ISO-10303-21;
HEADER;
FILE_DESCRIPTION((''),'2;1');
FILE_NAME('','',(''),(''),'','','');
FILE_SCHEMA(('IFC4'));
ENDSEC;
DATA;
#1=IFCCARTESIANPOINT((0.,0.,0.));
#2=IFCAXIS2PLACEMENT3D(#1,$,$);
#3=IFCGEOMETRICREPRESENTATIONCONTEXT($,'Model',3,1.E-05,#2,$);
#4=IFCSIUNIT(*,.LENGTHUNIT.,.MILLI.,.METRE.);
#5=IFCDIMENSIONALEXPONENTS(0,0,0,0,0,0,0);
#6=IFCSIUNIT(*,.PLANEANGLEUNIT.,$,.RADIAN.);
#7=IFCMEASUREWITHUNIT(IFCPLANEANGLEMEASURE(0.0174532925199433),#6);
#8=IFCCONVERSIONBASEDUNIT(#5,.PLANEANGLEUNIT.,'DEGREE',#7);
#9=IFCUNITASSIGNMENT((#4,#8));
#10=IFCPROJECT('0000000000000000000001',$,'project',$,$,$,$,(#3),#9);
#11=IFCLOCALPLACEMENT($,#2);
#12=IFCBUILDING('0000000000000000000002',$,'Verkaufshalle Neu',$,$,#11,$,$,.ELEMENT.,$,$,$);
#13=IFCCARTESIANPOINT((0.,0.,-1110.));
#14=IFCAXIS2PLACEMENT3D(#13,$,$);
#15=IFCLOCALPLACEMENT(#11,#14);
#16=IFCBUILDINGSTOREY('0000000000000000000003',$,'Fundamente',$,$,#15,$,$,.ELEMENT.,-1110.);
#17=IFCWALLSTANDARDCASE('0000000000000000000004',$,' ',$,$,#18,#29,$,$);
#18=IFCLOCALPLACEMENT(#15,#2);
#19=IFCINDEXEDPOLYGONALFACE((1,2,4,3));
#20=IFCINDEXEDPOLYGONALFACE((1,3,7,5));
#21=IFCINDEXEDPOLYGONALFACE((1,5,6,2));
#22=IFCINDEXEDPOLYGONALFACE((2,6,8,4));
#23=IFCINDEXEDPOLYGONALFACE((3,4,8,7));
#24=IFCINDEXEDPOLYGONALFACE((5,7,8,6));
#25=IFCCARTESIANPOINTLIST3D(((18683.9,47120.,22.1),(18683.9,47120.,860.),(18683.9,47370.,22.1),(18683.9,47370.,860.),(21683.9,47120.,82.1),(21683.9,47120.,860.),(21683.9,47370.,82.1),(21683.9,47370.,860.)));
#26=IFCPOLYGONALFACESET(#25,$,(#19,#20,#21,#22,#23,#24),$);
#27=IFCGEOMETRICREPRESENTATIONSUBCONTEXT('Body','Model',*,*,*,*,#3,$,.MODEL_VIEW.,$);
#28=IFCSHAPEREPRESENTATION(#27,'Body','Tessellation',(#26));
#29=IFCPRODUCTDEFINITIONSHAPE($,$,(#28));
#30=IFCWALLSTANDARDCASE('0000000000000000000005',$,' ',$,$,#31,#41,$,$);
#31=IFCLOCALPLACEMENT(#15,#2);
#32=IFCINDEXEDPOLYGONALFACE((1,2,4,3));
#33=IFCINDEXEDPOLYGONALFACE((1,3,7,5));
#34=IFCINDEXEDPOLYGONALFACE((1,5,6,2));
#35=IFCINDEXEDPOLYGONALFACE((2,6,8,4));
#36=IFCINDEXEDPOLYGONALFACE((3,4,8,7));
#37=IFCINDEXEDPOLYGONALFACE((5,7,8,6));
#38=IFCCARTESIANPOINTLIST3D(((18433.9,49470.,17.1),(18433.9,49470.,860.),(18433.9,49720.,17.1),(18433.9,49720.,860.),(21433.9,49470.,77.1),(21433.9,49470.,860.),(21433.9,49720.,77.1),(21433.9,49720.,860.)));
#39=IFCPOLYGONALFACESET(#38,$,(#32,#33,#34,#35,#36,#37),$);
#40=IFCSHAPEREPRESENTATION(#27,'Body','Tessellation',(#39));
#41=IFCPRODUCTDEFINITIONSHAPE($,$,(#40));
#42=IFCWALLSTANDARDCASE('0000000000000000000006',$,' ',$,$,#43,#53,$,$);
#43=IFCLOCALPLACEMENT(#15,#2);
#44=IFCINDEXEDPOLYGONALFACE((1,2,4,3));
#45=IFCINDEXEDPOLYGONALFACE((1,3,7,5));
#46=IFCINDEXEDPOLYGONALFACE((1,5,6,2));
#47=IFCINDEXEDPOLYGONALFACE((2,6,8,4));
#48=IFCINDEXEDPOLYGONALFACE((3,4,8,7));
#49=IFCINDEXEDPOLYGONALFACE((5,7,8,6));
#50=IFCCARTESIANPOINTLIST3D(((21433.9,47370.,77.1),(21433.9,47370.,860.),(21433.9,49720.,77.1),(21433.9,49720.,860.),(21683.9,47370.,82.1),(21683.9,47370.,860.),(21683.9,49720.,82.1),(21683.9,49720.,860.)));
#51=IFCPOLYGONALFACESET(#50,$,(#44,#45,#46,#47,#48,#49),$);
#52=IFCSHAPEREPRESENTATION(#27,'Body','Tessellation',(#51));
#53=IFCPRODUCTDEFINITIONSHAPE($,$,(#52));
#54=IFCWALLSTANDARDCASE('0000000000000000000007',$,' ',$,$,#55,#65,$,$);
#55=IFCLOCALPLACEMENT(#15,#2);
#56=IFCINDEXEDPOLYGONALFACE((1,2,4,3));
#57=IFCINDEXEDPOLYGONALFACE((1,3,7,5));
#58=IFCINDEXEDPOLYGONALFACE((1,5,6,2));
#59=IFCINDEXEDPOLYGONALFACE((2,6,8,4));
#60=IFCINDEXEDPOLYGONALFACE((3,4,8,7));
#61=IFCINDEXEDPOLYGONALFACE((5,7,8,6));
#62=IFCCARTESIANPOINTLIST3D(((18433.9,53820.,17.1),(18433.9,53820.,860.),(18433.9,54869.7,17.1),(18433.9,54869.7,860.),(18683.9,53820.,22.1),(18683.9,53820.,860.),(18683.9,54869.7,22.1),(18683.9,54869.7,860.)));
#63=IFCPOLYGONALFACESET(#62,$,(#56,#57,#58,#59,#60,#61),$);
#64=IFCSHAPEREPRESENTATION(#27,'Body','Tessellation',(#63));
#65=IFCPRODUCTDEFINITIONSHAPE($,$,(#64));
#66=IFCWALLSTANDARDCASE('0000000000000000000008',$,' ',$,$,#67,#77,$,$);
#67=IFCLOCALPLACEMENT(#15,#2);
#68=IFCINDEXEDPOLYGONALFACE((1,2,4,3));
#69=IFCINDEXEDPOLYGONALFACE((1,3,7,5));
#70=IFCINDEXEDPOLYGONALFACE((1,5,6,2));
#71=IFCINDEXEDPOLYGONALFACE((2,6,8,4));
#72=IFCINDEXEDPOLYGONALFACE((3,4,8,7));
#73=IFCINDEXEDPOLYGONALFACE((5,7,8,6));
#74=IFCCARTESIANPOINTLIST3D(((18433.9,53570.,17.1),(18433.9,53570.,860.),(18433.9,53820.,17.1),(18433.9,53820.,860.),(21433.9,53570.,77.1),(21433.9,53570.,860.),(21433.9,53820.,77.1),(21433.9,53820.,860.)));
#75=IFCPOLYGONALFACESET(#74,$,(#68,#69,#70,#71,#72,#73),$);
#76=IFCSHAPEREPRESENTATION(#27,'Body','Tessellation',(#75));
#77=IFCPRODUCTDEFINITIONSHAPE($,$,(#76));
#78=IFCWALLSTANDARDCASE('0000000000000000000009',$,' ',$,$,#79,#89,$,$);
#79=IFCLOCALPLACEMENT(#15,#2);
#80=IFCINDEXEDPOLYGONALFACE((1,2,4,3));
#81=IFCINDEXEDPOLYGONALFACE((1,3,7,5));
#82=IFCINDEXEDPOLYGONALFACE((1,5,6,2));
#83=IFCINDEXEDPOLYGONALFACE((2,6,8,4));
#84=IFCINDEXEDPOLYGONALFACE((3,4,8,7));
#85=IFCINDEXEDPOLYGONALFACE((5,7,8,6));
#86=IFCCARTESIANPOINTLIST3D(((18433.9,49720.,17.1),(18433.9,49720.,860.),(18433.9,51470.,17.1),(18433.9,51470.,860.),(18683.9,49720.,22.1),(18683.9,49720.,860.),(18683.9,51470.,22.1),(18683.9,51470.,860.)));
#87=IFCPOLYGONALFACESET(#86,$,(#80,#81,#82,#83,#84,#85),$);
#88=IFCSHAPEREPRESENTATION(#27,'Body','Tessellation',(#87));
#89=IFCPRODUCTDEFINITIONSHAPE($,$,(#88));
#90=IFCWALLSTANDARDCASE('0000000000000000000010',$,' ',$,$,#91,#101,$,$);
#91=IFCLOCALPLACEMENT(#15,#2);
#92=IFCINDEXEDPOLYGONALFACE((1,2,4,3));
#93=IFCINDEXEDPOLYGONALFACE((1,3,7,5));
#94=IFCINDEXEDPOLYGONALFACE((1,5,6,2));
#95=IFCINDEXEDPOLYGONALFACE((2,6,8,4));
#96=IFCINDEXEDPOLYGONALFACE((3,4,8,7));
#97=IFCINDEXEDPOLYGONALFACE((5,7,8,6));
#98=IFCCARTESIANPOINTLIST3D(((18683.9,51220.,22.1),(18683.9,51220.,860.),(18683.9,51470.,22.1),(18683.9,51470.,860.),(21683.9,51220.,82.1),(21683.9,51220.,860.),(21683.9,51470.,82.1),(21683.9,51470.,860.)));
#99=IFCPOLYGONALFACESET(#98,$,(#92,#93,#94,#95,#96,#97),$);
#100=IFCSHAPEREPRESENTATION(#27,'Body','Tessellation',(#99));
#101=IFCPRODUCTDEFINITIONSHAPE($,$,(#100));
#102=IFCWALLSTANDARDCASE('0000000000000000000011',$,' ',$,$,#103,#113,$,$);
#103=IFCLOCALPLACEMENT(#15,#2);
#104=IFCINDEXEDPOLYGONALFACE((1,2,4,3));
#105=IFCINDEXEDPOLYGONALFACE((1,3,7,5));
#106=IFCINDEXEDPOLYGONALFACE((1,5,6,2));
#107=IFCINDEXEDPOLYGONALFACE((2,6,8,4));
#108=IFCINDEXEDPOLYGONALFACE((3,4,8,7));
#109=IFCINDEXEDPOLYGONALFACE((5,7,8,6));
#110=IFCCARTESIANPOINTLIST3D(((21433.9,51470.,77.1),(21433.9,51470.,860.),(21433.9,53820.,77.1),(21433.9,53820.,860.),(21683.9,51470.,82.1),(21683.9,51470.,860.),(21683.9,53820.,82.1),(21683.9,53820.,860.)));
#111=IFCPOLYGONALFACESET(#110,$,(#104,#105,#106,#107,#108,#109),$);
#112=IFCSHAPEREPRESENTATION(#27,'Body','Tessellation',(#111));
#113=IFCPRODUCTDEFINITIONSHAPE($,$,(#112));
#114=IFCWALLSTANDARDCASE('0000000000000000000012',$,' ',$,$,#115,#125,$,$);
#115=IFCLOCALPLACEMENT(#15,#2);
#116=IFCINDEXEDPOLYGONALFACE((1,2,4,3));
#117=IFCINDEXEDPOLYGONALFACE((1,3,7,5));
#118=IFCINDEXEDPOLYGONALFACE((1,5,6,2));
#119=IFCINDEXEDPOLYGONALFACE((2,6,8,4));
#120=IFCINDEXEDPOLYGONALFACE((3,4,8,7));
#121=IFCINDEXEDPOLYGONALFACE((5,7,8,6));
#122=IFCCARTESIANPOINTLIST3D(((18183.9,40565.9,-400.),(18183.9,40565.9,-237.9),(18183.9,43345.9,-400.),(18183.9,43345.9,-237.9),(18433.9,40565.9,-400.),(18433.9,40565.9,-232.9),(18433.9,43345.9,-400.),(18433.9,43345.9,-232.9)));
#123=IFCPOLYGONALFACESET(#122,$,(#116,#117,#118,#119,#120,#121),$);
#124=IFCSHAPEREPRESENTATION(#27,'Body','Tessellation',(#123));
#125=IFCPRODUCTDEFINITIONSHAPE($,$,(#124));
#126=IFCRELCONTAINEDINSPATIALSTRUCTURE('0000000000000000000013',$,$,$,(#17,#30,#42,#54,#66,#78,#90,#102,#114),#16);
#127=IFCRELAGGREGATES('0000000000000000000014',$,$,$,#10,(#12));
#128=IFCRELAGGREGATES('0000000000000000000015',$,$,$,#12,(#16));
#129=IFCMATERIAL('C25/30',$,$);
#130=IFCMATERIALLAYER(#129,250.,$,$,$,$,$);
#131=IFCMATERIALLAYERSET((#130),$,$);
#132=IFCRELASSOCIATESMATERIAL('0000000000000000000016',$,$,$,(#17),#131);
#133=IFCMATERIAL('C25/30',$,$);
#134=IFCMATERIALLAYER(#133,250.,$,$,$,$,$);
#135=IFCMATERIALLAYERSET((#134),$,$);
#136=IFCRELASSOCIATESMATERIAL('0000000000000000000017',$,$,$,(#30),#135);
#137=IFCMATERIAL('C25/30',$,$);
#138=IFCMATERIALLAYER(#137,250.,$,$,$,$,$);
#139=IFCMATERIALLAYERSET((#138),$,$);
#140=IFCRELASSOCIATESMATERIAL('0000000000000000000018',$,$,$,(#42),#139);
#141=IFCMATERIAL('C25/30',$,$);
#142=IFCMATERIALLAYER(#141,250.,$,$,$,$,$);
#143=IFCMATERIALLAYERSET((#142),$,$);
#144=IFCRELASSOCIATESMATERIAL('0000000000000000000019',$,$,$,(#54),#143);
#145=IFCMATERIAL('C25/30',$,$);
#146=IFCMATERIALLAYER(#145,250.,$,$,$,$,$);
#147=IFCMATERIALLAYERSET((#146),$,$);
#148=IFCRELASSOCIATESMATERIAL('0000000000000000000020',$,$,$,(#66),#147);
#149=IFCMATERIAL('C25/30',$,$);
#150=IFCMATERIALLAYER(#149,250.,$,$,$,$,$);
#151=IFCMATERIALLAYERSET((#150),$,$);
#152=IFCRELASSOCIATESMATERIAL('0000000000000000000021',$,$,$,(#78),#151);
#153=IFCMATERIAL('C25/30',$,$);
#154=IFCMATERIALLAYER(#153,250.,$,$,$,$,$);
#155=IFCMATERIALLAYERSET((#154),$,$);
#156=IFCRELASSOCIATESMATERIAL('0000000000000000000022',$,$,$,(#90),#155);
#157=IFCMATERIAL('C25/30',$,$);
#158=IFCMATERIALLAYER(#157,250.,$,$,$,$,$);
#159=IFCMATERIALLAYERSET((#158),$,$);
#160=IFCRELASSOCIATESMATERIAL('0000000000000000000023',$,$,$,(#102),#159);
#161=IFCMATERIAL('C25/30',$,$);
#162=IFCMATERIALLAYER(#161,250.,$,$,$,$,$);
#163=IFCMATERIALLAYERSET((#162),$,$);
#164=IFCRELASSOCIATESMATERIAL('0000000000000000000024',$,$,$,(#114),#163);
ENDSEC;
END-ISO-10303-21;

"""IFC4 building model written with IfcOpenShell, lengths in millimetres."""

from ifc_helpers import new_model, entity, si_unit, converted_unit, frame, frame_2d, origin, origin_with_axes, place, context, subcontext, project, spatial, rectangle, extrude, clip, halfspace, material, layer, layer_set, layer_usage, element, save


model = new_model("IFC4")

# Units and contexts
model_context = context("Model", 3, precision=1e-05, world=origin())
body_context = subcontext(model_context, "Body", "Model", "MODEL_VIEW")
ifc_project = project(units=[si_unit("LENGTHUNIT", "METRE", prefix="MILLI"), converted_unit("PLANEANGLEUNIT", "DEGREE", entity("IfcPlaneAngleMeasure", 0.0174532925199433), si_unit("PLANEANGLEUNIT", "RADIAN"), dimensions=[0, 0, 0, 0, 0, 0, 0])], contexts=[model_context])

# Building, storey
building_placement = place(None, origin())
building = spatial("IfcBuilding", under=ifc_project, at=building_placement, Name="Verkaufshalle Neu", CompositionType="ELEMENT")
storey_placement = place(building_placement, frame((0.0, 0.0, -1110.0)))
storey = spatial("IfcBuildingStorey", under=building, at=storey_placement, Name="Fundamente", CompositionType="ELEMENT", Elevation=-1110.0)

# Walls
ifc_material_1 = material(Name="C25/30")
ifc_layer_1 = layer(ifc_material_1, 250.0)
ifc_layer_set_1 = layer_set([ifc_layer_1])
ifc_layer_usage_1 = layer_usage(ifc_layer_set_1, "AXIS2", "POSITIVE", 0.0)
wall_1_placement = place(storey_placement, frame((18683.9, 47120.0, 22.1)))
element("IfcWallStandardCase", 1, at=wall_1_placement, inside=storey, material=ifc_layer_usage_1, Name=" ", context=body_context, shape_type="Clipping", body=[
    clip(extrude(rectangle(XDim=3000.0, YDim=250.0, at=frame_2d((1500.0, 125.0), x_axis=(1.0, 0.0))), origin_with_axes(), (0.0, 0.0, 1.0), 837.9), halfspace(frame((1500.0, 125.0, 30.0), z_axis=(-0.019996, 0.0, 0.9998), x_axis=(0.0, -1.0, 0.0)), True)),
])
ifc_material_2 = material(Name="C25/30")
ifc_layer_2 = layer(ifc_material_2, 250.0)
ifc_layer_set_2 = layer_set([ifc_layer_2])
ifc_layer_usage_2 = layer_usage(ifc_layer_set_2, "AXIS2", "POSITIVE", 0.0)
wall_2_placement = place(storey_placement, frame((21433.9, 49720.0, 17.1), z_axis=(0.0, 0.0, 1.0), x_axis=(-1.0, 0.0, 0.0)))
element("IfcWallStandardCase", 2, at=wall_2_placement, inside=storey, material=ifc_layer_usage_2, Name=" ", context=body_context, shape_type="Clipping", body=[
    clip(extrude(rectangle(XDim=3000.0, YDim=250.0, at=frame_2d((1500.0, 125.0), x_axis=(1.0, 0.0))), origin_with_axes(), (0.0, 0.0, 1.0), 842.9), halfspace(frame((1500.0, 125.0, 30.0), z_axis=(0.019996, 0.0, 0.9998), x_axis=(0.0, -1.0, 0.0)), True)),
])
ifc_material_3 = material(Name="C25/30")
ifc_layer_3 = layer(ifc_material_3, 250.0)
ifc_layer_set_3 = layer_set([ifc_layer_3])
ifc_layer_usage_3 = layer_usage(ifc_layer_set_3, "AXIS2", "POSITIVE", 0.0)
wall_3_placement = place(storey_placement, frame((21683.9, 47370.0, 77.1), z_axis=(0.0, 0.0, 1.0), x_axis=(0.0, 1.0, 0.0)))
element("IfcWallStandardCase", 3, at=wall_3_placement, inside=storey, material=ifc_layer_usage_3, Name=" ", context=body_context, shape_type="Clipping", body=[
    clip(extrude(rectangle(XDim=2350.0, YDim=250.0, at=frame_2d((1175.0, 125.0), x_axis=(1.0, 0.0))), origin_with_axes(), (0.0, 0.0, 1.0), 782.9), halfspace(frame((1175.0, 125.0, 2.5), z_axis=(0.0, 0.019996, 0.9998), x_axis=(0.0, -0.9998, 0.019996)), True)),
])
ifc_material_4 = material(Name="C25/30")
ifc_layer_4 = layer(ifc_material_4, 250.0)
ifc_layer_set_4 = layer_set([ifc_layer_4])
ifc_layer_usage_4 = layer_usage(ifc_layer_set_4, "AXIS2", "POSITIVE", 0.0)
wall_4_placement = place(storey_placement, frame((18683.9, 53820.0, 17.1), z_axis=(0.0, 0.0, 1.0), x_axis=(0.0, 1.0, 0.0)))
element("IfcWallStandardCase", 4, at=wall_4_placement, inside=storey, material=ifc_layer_usage_4, Name=" ", context=body_context, shape_type="Clipping", body=[
    clip(extrude(rectangle(XDim=1049.7, YDim=250.0, at=frame_2d((524.9, 125.0), x_axis=(1.0, 0.0))), origin_with_axes(), (0.0, 0.0, 1.0), 842.9), halfspace(frame((524.9, 125.0, 2.5), z_axis=(0.0, 0.019996, 0.9998), x_axis=(0.0, -0.9998, 0.019996)), True)),
])
ifc_material_5 = material(Name="C25/30")
ifc_layer_5 = layer(ifc_material_5, 250.0)
ifc_layer_set_5 = layer_set([ifc_layer_5])
ifc_layer_usage_5 = layer_usage(ifc_layer_set_5, "AXIS2", "POSITIVE", 0.0)
wall_5_placement = place(storey_placement, frame((21433.9, 53820.0, 17.1), z_axis=(0.0, 0.0, 1.0), x_axis=(-1.0, 0.0, 0.0)))
element("IfcWallStandardCase", 5, at=wall_5_placement, inside=storey, material=ifc_layer_usage_5, Name=" ", context=body_context, shape_type="Clipping", body=[
    clip(extrude(rectangle(XDim=3000.0, YDim=250.0, at=frame_2d((1500.0, 125.0), x_axis=(1.0, 0.0))), origin_with_axes(), (0.0, 0.0, 1.0), 842.9), halfspace(frame((1500.0, 125.0, 30.0), z_axis=(0.019996, 0.0, 0.9998), x_axis=(0.0, -1.0, 0.0)), True)),
])
ifc_material_6 = material(Name="C25/30")
ifc_layer_6 = layer(ifc_material_6, 250.0)
ifc_layer_set_6 = layer_set([ifc_layer_6])
ifc_layer_usage_6 = layer_usage(ifc_layer_set_6, "AXIS2", "POSITIVE", 0.0)
wall_6_placement = place(storey_placement, frame((18683.9, 49720.0, 17.1), z_axis=(0.0, 0.0, 1.0), x_axis=(0.0, 1.0, 0.0)))
element("IfcWallStandardCase", 6, at=wall_6_placement, inside=storey, material=ifc_layer_usage_6, Name=" ", context=body_context, shape_type="Clipping", body=[
    clip(extrude(rectangle(XDim=1750.0, YDim=250.0, at=frame_2d((875.0, 125.0), x_axis=(1.0, 0.0))), origin_with_axes(), (0.0, 0.0, 1.0), 842.9), halfspace(frame((875.0, 125.0, 2.5), z_axis=(0.0, 0.019996, 0.9998), x_axis=(0.0, -0.9998, 0.019996)), True)),
])
ifc_material_7 = material(Name="C25/30")
ifc_layer_7 = layer(ifc_material_7, 250.0)
ifc_layer_set_7 = layer_set([ifc_layer_7])
ifc_layer_usage_7 = layer_usage(ifc_layer_set_7, "AXIS2", "POSITIVE", 0.0)
wall_7_placement = place(storey_placement, frame((18683.9, 51220.0, 22.1)))
element("IfcWallStandardCase", 7, at=wall_7_placement, inside=storey, material=ifc_layer_usage_7, Name=" ", context=body_context, shape_type="Clipping", body=[
    clip(extrude(rectangle(XDim=3000.0, YDim=250.0, at=frame_2d((1500.0, 125.0), x_axis=(1.0, 0.0))), origin_with_axes(), (0.0, 0.0, 1.0), 837.9), halfspace(frame((1500.0, 125.0, 30.0), z_axis=(-0.019996, 0.0, 0.9998), x_axis=(0.0, -1.0, 0.0)), True)),
])
ifc_material_8 = material(Name="C25/30")
ifc_layer_8 = layer(ifc_material_8, 250.0)
ifc_layer_set_8 = layer_set([ifc_layer_8])
ifc_layer_usage_8 = layer_usage(ifc_layer_set_8, "AXIS2", "POSITIVE", 0.0)
wall_8_placement = place(storey_placement, frame((21683.9, 51470.0, 77.1), z_axis=(0.0, 0.0, 1.0), x_axis=(0.0, 1.0, 0.0)))
element("IfcWallStandardCase", 8, at=wall_8_placement, inside=storey, material=ifc_layer_usage_8, Name=" ", context=body_context, shape_type="Clipping", body=[
    clip(extrude(rectangle(XDim=2350.0, YDim=250.0, at=frame_2d((1175.0, 125.0), x_axis=(1.0, 0.0))), origin_with_axes(), (0.0, 0.0, 1.0), 782.9), halfspace(frame((1175.0, 125.0, 2.5), z_axis=(0.0, 0.019996, 0.9998), x_axis=(0.0, -0.9998, 0.019996)), True)),
])
ifc_material_9 = material(Name="C25/30")
ifc_layer_9 = layer(ifc_material_9, 250.0)
ifc_layer_set_9 = layer_set([ifc_layer_9])
ifc_layer_usage_9 = layer_usage(ifc_layer_set_9, "AXIS2", "POSITIVE", 0.0)
wall_9_placement = place(storey_placement, frame((18183.9, 43345.9, -400.0), z_axis=(0.0, 0.0, 1.0), x_axis=(0.0, -1.0, 0.0)))
element("IfcWallStandardCase", 9, at=wall_9_placement, inside=storey, material=ifc_layer_usage_9, Name=" ", context=body_context, shape_type="Clipping", body=[
    clip(extrude(rectangle(XDim=2780.0, YDim=250.0, at=frame_2d((1390.0, 125.0), x_axis=(1.0, 0.0))), origin_with_axes(), (0.0, 0.0, 1.0), 167.1), halfspace(frame((1390.0, 125.0, 164.6), z_axis=(0.0, 0.019996, -0.9998), x_axis=(1.0, 0.0, 0.0)), True)),
])

save(model, "model.ifc")
